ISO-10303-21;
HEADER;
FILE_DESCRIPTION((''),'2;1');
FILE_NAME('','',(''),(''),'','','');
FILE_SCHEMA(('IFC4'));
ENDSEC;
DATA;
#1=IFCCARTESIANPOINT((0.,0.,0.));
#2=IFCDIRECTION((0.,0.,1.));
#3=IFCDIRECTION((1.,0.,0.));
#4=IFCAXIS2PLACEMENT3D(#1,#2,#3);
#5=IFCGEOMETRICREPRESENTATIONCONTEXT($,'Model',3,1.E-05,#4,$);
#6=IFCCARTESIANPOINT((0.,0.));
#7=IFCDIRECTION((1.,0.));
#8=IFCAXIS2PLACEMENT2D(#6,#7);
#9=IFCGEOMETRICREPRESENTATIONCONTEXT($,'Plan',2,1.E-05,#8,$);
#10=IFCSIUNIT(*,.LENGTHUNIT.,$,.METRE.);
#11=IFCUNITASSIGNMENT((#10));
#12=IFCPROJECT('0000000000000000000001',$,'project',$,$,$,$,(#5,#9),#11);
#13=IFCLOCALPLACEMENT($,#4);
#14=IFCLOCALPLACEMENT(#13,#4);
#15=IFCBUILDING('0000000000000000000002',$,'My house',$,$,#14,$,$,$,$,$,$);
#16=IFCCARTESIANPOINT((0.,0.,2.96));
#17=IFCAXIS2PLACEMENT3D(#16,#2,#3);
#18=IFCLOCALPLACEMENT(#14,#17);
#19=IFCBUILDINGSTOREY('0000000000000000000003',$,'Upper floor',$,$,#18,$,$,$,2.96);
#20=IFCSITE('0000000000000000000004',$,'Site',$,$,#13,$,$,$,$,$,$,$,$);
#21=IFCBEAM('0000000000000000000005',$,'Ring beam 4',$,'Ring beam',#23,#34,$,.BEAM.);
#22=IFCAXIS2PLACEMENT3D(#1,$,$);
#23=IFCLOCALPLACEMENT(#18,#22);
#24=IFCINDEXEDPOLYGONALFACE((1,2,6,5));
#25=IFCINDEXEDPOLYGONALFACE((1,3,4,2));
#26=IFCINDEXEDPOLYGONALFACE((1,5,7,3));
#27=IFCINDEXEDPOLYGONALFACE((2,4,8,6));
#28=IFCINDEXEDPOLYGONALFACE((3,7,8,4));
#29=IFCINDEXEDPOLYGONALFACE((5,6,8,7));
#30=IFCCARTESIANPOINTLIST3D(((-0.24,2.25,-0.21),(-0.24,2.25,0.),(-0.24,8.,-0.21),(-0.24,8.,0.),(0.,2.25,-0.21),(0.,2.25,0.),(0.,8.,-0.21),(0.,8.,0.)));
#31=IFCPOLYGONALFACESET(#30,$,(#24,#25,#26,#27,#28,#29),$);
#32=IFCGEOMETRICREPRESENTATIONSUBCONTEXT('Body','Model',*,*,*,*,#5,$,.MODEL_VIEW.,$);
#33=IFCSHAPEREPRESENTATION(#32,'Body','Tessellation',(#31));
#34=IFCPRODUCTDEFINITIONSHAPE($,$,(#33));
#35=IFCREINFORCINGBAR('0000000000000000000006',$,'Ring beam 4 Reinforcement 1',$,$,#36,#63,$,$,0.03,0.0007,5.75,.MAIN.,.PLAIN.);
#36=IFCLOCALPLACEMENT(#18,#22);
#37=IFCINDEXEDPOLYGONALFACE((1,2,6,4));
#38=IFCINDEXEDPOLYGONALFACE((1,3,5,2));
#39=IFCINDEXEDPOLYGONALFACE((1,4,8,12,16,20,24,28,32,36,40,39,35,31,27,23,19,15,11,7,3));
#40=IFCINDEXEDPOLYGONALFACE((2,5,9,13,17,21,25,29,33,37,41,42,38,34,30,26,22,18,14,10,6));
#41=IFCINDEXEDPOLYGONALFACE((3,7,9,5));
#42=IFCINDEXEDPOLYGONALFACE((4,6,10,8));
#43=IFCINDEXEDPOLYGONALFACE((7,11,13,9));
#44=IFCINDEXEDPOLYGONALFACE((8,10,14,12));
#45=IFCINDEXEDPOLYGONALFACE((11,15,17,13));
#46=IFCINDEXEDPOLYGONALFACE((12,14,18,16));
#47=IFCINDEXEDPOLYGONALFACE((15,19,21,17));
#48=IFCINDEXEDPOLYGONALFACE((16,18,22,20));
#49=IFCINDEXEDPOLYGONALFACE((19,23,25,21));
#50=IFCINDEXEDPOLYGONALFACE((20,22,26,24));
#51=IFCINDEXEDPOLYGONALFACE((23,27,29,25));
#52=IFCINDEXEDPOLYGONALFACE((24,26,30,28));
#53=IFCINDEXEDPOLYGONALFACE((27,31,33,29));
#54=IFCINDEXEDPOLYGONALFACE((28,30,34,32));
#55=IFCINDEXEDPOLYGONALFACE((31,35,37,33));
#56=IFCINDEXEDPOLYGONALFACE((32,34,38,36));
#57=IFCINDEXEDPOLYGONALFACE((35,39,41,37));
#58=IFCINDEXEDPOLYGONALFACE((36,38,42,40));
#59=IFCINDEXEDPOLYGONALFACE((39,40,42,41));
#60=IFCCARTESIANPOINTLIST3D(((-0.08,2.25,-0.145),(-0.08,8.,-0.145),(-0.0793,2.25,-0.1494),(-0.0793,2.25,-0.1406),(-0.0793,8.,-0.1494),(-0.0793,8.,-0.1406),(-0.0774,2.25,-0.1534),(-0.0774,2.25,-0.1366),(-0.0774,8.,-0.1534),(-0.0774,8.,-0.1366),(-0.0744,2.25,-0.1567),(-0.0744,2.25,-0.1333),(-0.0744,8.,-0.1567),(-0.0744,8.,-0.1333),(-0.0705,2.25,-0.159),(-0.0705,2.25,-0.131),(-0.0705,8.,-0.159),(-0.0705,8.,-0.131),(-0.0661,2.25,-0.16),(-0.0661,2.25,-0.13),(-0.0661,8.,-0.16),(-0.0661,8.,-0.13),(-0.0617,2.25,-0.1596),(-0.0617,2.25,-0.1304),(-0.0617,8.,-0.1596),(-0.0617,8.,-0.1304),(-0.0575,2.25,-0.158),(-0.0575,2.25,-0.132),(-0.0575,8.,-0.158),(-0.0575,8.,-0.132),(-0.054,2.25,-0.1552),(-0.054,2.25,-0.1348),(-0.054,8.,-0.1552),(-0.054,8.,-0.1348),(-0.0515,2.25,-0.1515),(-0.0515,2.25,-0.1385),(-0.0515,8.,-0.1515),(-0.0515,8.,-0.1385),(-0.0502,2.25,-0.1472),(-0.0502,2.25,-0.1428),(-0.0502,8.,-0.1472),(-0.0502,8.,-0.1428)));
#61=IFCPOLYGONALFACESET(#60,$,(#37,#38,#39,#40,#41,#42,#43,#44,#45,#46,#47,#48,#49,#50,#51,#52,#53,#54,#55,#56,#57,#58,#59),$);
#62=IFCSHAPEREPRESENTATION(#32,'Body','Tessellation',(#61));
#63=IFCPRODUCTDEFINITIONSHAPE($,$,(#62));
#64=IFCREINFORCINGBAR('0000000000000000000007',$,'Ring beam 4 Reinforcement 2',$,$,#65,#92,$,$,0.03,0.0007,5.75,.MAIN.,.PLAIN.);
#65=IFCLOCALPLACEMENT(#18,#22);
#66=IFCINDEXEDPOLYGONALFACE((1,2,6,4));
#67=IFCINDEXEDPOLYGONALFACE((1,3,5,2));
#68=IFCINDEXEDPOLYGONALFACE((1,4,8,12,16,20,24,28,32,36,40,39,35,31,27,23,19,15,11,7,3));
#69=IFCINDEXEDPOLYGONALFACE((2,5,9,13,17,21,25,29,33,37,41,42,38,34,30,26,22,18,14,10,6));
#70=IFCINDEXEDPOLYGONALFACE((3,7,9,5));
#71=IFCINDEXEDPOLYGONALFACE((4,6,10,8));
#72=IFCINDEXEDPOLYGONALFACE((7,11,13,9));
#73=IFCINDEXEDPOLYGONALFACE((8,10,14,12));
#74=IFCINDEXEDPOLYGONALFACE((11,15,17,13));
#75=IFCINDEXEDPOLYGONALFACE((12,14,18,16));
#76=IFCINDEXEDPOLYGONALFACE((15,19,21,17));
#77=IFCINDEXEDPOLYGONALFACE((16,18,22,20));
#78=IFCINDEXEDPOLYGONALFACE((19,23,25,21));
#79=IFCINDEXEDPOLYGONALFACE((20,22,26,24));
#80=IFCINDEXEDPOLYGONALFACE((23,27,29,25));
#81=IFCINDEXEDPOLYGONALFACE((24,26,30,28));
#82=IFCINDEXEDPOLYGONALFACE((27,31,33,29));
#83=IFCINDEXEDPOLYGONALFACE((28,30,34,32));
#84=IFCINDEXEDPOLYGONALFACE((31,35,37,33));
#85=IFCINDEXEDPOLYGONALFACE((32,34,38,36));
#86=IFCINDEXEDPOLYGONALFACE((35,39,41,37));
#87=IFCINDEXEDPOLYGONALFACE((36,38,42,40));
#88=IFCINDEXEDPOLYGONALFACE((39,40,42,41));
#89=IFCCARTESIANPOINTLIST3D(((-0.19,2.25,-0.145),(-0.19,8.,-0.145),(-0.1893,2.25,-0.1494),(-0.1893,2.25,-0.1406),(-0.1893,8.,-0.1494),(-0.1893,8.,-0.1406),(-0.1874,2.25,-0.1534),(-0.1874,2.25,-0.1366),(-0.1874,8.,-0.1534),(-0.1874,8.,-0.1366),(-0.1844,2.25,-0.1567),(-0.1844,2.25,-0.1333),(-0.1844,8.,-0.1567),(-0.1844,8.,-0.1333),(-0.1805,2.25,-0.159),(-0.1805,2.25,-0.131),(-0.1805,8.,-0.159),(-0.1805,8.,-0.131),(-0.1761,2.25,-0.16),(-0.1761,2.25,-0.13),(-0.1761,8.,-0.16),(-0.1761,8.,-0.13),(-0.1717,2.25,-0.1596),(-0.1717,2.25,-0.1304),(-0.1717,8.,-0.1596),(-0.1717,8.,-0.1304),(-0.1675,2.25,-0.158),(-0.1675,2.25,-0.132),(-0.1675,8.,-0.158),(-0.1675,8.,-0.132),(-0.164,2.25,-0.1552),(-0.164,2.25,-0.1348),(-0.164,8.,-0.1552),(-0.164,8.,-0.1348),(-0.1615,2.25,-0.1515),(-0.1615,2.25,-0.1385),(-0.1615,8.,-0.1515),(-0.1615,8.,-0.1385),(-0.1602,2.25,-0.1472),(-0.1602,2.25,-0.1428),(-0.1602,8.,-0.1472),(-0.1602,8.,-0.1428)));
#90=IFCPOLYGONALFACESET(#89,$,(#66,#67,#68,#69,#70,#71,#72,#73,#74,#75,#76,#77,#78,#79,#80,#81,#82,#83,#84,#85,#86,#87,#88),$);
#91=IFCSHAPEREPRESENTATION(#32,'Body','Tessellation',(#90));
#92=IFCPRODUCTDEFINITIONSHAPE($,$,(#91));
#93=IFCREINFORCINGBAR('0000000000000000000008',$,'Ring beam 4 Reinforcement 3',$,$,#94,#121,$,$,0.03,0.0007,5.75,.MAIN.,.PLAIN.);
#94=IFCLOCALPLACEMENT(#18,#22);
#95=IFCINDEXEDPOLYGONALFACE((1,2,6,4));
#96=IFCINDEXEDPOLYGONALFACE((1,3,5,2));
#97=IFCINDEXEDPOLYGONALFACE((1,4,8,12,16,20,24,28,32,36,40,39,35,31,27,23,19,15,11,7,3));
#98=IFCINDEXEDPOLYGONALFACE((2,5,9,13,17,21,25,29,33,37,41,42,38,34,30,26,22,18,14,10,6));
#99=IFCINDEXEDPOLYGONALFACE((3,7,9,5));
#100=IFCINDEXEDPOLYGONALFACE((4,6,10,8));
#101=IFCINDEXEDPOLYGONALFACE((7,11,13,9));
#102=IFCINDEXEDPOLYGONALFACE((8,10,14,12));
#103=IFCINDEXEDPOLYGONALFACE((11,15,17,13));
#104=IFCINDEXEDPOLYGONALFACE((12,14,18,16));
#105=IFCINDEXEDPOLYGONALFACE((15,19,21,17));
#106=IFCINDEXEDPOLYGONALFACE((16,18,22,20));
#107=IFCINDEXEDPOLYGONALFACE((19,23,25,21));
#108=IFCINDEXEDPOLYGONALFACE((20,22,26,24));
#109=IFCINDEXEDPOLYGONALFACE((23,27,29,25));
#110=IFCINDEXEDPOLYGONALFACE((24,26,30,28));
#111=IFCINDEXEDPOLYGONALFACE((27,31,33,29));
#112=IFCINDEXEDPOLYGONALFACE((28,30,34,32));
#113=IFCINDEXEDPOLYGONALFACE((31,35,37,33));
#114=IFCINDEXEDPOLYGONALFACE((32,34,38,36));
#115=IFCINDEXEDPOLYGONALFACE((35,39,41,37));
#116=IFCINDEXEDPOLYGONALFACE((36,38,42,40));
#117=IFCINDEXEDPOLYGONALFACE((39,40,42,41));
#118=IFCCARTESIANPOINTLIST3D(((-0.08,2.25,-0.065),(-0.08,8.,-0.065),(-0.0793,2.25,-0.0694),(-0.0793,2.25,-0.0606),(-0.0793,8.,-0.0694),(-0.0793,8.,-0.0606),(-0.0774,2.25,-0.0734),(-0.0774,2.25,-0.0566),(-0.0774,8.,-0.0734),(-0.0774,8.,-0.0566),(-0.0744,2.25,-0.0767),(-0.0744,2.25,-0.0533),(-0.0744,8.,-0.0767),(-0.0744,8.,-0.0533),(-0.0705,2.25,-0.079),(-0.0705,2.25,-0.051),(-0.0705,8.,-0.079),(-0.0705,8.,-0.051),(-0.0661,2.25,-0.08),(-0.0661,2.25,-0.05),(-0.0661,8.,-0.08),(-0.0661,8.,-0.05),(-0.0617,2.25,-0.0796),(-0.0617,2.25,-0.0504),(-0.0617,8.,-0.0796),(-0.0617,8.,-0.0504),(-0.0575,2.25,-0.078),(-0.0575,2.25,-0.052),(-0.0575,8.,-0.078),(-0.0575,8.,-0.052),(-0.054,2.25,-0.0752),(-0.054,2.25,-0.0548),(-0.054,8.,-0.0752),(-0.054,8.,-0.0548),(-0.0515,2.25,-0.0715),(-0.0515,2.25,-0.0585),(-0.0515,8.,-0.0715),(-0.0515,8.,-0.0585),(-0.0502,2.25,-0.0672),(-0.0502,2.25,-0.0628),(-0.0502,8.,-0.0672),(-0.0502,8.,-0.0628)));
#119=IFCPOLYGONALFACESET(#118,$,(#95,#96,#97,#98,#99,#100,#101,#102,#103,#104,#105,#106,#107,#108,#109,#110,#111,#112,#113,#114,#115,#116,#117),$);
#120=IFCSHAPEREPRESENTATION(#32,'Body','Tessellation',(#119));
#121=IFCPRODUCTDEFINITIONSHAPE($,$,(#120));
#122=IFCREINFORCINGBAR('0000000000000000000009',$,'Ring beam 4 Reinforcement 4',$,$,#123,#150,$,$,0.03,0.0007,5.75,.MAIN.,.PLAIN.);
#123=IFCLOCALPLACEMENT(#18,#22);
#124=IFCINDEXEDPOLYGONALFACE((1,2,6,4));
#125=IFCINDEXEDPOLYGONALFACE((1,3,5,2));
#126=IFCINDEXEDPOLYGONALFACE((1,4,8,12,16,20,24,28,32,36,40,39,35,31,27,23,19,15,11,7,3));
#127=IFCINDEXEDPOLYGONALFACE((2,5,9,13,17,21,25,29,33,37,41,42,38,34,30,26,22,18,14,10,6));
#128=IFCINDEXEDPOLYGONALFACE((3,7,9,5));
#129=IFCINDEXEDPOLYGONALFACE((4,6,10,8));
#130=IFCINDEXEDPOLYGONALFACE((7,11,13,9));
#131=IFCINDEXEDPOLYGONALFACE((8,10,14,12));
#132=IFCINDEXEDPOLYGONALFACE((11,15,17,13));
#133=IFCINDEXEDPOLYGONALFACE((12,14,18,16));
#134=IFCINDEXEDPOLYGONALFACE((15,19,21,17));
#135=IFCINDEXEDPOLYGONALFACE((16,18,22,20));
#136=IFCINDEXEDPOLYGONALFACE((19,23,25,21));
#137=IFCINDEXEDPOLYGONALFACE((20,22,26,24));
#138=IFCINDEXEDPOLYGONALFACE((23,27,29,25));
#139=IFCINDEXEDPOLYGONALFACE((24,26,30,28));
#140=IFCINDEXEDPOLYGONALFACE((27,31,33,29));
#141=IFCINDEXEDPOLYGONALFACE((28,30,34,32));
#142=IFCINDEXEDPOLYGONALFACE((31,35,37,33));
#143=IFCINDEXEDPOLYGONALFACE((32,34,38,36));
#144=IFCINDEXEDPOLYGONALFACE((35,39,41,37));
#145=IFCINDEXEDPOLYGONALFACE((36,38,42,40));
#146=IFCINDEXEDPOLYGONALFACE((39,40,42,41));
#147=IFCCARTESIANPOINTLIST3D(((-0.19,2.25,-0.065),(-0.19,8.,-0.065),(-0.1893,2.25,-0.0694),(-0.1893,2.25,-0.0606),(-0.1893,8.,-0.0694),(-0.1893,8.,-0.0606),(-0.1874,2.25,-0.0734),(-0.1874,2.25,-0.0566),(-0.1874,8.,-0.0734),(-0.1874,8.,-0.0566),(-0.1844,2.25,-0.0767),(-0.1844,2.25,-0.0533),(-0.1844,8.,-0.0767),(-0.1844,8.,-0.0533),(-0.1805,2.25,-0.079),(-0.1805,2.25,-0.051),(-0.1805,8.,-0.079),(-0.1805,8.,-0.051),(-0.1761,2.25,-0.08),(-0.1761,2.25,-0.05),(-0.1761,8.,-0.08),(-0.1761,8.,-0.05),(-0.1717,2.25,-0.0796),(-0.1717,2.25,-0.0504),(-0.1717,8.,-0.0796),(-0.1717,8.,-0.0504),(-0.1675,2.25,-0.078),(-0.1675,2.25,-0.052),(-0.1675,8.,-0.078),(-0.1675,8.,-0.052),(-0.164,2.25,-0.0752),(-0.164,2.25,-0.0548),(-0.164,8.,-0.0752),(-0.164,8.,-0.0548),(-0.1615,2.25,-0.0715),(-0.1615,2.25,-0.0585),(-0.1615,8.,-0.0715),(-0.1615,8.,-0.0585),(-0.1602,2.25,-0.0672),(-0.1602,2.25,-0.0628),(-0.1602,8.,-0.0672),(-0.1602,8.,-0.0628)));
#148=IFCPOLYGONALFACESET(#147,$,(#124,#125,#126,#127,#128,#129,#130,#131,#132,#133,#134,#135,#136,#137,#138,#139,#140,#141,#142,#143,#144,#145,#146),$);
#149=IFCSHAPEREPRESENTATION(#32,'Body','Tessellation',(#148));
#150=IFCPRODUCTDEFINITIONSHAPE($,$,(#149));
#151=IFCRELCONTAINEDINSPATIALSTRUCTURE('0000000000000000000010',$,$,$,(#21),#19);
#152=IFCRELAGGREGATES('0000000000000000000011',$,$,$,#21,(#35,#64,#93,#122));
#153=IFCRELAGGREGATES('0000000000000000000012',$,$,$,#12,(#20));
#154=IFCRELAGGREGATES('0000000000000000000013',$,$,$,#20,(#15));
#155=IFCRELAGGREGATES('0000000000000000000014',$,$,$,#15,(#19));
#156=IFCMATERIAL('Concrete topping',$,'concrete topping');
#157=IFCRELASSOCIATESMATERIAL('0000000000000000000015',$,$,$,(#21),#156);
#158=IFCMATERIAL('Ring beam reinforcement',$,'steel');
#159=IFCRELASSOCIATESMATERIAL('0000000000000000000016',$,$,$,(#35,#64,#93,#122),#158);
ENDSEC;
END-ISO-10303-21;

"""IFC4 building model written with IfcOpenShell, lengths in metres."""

from ifc_helpers import new_model, si_unit, frame, origin_with_axes, origin_2d, origin_2d_with_axis, place, context, subcontext, project, spatial, circle_curve, rectangle, outline, extrude, source, transform, mapped, material, element, aggregate, save


model = new_model("IFC4")

# Units and contexts
model_context = context("Model", 3, precision=1e-05, world=origin_with_axes())
plan_context = context("Plan", 2, precision=1e-05, world=origin_2d_with_axis())
body_context_1 = subcontext(model_context, "Body", "Model", "MODEL_VIEW")
ifc_project = project(units=[si_unit("LENGTHUNIT", "METRE")], contexts=[model_context, plan_context])

# Site, building, storey
site_placement = place(None, origin_with_axes())
site = spatial("IfcSite", under=ifc_project, at=site_placement, Name="Site")
building_placement = place(site_placement, origin_with_axes())
building = spatial("IfcBuilding", under=site, at=building_placement, Name="My house")
storey_placement = place(building_placement, frame((0.0, 0.0, 2.96), z_axis=(0.0, 0.0, 1.0), x_axis=(1.0, 0.0, 0.0)))
storey = spatial("IfcBuildingStorey", under=building, at=storey_placement, Name="Upper floor", Elevation=2.96)

# Beam
ifc_material_1 = material(Name="Concrete topping", Category="concrete topping")
shared_shape_1 = source(origin_with_axes(), body_context_1, "Body", "SweptSolid", [
    extrude(rectangle(XDim=0.24, YDim=0.21), frame((0.0, 0.0, 0.0), z_axis=(1.0, 0.0, 0.0), x_axis=(0.0, 1.0, 0.0)), (0.0, 0.0, 1.0), 5.75),
])
beam_1_placement = place(storey_placement, frame((-0.12, 8.0, -0.105), z_axis=(0.0, 0.0, 1.0), x_axis=(0.0, 1.0, 0.0)))
beam_1 = element("IfcBeam", 1, at=beam_1_placement, inside=storey, material=ifc_material_1, Name="Ring beam 4", ObjectType="Ring beam", PredefinedType="BEAM", context=body_context_1, shape_type="MappedRepresentation", body=[
    mapped(shared_shape_1, transform((0.0, 0.0, 0.0), x_axis=(-1.0, 0.0, 0.0), y_axis=(0.0, 1.0, 0.0), z_axis=(0.0, 0.0, 1.0), scale=1.0)),
])

# Reinforcing bars
ifc_material_2 = material(Name="Ring beam reinforcement", Category="steel")
shared_shape_2 = source(origin_with_axes(), body_context_1, "Body", "SweptSolid", [
    extrude(outline(circle_curve(origin_2d(), 0.015)), frame((0.0, 0.0, 0.0), z_axis=(1.0, 0.0, 0.0), x_axis=(0.0, 1.0, 0.0)), (0.0, 0.0, 1.0), 5.75),
])
reinforcing_bar_1_placement = place(beam_1_placement, frame((0.0, -0.055, -0.04), z_axis=(0.0, 0.0, 1.0), x_axis=(1.0, 0.0, 0.0)))
reinforcing_bar_1 = element("IfcReinforcingBar", 2, at=reinforcing_bar_1_placement, material=ifc_material_2, Name="Ring beam 4 Reinforcement 1", BarLength=5.75, BarSurface="PLAIN", CrossSectionArea=0.0007, NominalDiameter=0.03, PredefinedType="MAIN", context=body_context_1, shape_type="MappedRepresentation", body=[
    mapped(shared_shape_2, transform((0.0, 0.0, 0.0), x_axis=(-1.0, 0.0, 0.0), y_axis=(0.0, 1.0, 0.0), z_axis=(0.0, 0.0, 1.0), scale=1.0)),
])
shared_shape_3 = source(origin_with_axes(), body_context_1, "Body", "SweptSolid", [
    extrude(outline(circle_curve(origin_2d(), 0.015)), frame((0.0, 0.0, 0.0), z_axis=(1.0, 0.0, 0.0), x_axis=(0.0, 1.0, 0.0)), (0.0, 0.0, 1.0), 5.75),
])
reinforcing_bar_2_placement = place(beam_1_placement, frame((0.0, 0.055, -0.04), z_axis=(0.0, 0.0, 1.0), x_axis=(1.0, 0.0, 0.0)))
reinforcing_bar_2 = element("IfcReinforcingBar", 3, at=reinforcing_bar_2_placement, material=ifc_material_2, Name="Ring beam 4 Reinforcement 2", BarLength=5.75, BarSurface="PLAIN", CrossSectionArea=0.0007, NominalDiameter=0.03, PredefinedType="MAIN", context=body_context_1, shape_type="MappedRepresentation", body=[
    mapped(shared_shape_3, transform((0.0, 0.0, 0.0), x_axis=(-1.0, 0.0, 0.0), y_axis=(0.0, 1.0, 0.0), z_axis=(0.0, 0.0, 1.0), scale=1.0)),
])
shared_shape_4 = source(origin_with_axes(), body_context_1, "Body", "SweptSolid", [
    extrude(outline(circle_curve(origin_2d(), 0.015)), frame((0.0, 0.0, 0.0), z_axis=(1.0, 0.0, 0.0), x_axis=(0.0, 1.0, 0.0)), (0.0, 0.0, 1.0), 5.75),
])
reinforcing_bar_3_placement = place(beam_1_placement, frame((0.0, -0.055, 0.04), z_axis=(0.0, 0.0, 1.0), x_axis=(1.0, 0.0, 0.0)))
reinforcing_bar_3 = element("IfcReinforcingBar", 4, at=reinforcing_bar_3_placement, material=ifc_material_2, Name="Ring beam 4 Reinforcement 3", BarLength=5.75, BarSurface="PLAIN", CrossSectionArea=0.0007, NominalDiameter=0.03, PredefinedType="MAIN", context=body_context_1, shape_type="MappedRepresentation", body=[
    mapped(shared_shape_4, transform((0.0, 0.0, 0.0), x_axis=(-1.0, 0.0, 0.0), y_axis=(0.0, 1.0, 0.0), z_axis=(0.0, 0.0, 1.0), scale=1.0)),
])
shared_shape_5 = source(origin_with_axes(), body_context_1, "Body", "SweptSolid", [
    extrude(outline(circle_curve(origin_2d(), 0.015)), frame((0.0, 0.0, 0.0), z_axis=(1.0, 0.0, 0.0), x_axis=(0.0, 1.0, 0.0)), (0.0, 0.0, 1.0), 5.75),
])
reinforcing_bar_4_placement = place(beam_1_placement, frame((0.0, 0.055, 0.04), z_axis=(0.0, 0.0, 1.0), x_axis=(1.0, 0.0, 0.0)))
reinforcing_bar_4 = element("IfcReinforcingBar", 5, at=reinforcing_bar_4_placement, material=ifc_material_2, Name="Ring beam 4 Reinforcement 4", BarLength=5.75, BarSurface="PLAIN", CrossSectionArea=0.0007, NominalDiameter=0.03, PredefinedType="MAIN", context=body_context_1, shape_type="MappedRepresentation", body=[
    mapped(shared_shape_5, transform((0.0, 0.0, 0.0), x_axis=(-1.0, 0.0, 0.0), y_axis=(0.0, 1.0, 0.0), z_axis=(0.0, 0.0, 1.0), scale=1.0)),
])
aggregate(beam_1, [reinforcing_bar_1, reinforcing_bar_2, reinforcing_bar_3, reinforcing_bar_4])

save(model, "model.ifc")
